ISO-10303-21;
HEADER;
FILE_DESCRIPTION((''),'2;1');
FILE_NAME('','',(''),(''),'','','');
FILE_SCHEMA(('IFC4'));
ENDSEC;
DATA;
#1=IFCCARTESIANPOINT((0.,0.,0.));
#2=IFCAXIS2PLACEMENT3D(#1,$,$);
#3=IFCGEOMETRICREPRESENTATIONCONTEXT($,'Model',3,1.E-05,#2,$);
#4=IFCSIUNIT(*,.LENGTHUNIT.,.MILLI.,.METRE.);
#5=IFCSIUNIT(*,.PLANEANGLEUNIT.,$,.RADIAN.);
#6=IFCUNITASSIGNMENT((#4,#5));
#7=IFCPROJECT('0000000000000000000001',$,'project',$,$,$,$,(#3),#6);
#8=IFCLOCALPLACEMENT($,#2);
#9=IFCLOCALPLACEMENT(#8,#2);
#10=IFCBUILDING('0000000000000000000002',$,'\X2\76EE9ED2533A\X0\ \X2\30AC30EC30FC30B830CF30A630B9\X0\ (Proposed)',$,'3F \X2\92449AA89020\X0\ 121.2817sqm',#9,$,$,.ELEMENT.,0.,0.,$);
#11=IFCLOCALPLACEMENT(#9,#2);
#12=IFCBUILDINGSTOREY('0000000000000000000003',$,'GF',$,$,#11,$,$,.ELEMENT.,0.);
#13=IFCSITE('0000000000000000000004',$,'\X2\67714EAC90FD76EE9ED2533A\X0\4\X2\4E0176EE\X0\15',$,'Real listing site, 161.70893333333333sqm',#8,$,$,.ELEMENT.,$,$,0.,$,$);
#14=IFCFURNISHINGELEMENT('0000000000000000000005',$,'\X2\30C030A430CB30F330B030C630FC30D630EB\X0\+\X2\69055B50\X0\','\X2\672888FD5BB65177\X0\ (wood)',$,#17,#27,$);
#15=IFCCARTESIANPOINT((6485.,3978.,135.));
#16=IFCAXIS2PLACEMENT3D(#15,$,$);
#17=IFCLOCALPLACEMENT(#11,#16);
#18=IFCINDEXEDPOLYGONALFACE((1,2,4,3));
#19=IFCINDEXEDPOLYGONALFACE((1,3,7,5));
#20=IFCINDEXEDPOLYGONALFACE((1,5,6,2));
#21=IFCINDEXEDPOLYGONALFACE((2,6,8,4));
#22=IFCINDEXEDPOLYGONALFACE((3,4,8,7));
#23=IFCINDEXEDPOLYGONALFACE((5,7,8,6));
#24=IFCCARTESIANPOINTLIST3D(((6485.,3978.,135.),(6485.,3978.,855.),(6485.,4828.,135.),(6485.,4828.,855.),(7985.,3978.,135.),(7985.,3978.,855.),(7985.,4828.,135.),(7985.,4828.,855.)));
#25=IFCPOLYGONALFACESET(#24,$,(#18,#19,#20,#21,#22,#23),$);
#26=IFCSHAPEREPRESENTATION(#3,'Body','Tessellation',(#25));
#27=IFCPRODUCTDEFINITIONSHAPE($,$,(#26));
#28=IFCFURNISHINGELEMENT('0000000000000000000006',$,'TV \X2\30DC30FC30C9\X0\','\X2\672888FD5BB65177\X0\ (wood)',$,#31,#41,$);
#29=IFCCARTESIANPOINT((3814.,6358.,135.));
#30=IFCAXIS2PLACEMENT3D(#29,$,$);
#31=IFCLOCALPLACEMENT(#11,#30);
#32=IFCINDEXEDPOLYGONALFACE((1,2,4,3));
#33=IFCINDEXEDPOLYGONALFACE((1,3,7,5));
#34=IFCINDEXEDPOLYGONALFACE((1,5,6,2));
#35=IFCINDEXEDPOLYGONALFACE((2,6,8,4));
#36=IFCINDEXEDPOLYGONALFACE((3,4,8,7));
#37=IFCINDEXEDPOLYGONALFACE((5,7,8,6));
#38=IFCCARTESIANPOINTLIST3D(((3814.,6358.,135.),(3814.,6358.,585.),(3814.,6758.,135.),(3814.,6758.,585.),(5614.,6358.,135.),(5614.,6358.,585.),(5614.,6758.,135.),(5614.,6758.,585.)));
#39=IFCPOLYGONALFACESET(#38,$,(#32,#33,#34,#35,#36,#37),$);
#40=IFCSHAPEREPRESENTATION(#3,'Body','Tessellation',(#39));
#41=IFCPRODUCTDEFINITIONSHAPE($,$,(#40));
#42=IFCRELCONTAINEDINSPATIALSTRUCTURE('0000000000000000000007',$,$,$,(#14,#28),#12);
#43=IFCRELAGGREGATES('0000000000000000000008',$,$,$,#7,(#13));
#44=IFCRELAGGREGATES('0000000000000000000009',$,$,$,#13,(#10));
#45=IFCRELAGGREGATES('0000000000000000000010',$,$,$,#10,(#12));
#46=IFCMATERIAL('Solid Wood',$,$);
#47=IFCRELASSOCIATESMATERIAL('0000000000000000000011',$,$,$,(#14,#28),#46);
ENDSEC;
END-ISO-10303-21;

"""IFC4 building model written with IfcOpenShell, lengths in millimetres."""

from ifc_helpers import new_model, si_unit, frame, frame_2d, origin, place, context, project, spatial, rectangle, extrude, material, element, save


model = new_model("IFC4")

# Units and contexts
model_context = context("Model", 3, precision=1e-05, world=origin())
ifc_project = project(units=[si_unit("LENGTHUNIT", "METRE", prefix="MILLI"), si_unit("PLANEANGLEUNIT", "RADIAN")], contexts=[model_context])

# Site, building, storey
site_placement = place(None, origin())
site = spatial("IfcSite", under=ifc_project, at=site_placement, Name="東京都目黒区4丁目15", ObjectType="Real listing site, 161.70893333333333sqm", CompositionType="ELEMENT", RefElevation=0.0)
building_placement = place(site_placement, origin())
building = spatial("IfcBuilding", under=site, at=building_placement, Name="目黒区 ガレージハウス (Proposed)", ObjectType="3F 鉄骨造 121.2817sqm", CompositionType="ELEMENT", ElevationOfRefHeight=0.0, ElevationOfTerrain=0.0)
storey_placement = place(building_placement, origin())
storey = spatial("IfcBuildingStorey", under=building, at=storey_placement, Name="GF", CompositionType="ELEMENT", Elevation=0.0)

# Shared definitions
ifc_material_1 = material(Name="Solid Wood")

# Furnishing elements
furnishing_1_placement = place(storey_placement, frame((6485.0, 3978.0, 135.0)))
element("IfcFurnishingElement", 1, at=furnishing_1_placement, inside=storey, material=ifc_material_1, Name="ダイニングテーブル+椅子", Description="木製家具 (wood)", context=model_context, shape_type="SweptSolid", body=[
    extrude(rectangle(XDim=1500.0, YDim=850.0, at=frame_2d((750.0, 425.0))), frame((6485.0, 3978.0, 135.0)), (0.0, 0.0, 1.0), 720.0),
])
furnishing_2_placement = place(storey_placement, frame((3814.0, 6358.0, 135.0)))
element("IfcFurnishingElement", 2, at=furnishing_2_placement, inside=storey, material=ifc_material_1, Name="TV ボード", Description="木製家具 (wood)", context=model_context, shape_type="SweptSolid", body=[
    extrude(rectangle(XDim=1800.0, YDim=400.0, at=frame_2d((900.0, 200.0))), frame((3814.0, 6358.0, 135.0)), (0.0, 0.0, 1.0), 450.0),
])

save(model, "model.ifc")
